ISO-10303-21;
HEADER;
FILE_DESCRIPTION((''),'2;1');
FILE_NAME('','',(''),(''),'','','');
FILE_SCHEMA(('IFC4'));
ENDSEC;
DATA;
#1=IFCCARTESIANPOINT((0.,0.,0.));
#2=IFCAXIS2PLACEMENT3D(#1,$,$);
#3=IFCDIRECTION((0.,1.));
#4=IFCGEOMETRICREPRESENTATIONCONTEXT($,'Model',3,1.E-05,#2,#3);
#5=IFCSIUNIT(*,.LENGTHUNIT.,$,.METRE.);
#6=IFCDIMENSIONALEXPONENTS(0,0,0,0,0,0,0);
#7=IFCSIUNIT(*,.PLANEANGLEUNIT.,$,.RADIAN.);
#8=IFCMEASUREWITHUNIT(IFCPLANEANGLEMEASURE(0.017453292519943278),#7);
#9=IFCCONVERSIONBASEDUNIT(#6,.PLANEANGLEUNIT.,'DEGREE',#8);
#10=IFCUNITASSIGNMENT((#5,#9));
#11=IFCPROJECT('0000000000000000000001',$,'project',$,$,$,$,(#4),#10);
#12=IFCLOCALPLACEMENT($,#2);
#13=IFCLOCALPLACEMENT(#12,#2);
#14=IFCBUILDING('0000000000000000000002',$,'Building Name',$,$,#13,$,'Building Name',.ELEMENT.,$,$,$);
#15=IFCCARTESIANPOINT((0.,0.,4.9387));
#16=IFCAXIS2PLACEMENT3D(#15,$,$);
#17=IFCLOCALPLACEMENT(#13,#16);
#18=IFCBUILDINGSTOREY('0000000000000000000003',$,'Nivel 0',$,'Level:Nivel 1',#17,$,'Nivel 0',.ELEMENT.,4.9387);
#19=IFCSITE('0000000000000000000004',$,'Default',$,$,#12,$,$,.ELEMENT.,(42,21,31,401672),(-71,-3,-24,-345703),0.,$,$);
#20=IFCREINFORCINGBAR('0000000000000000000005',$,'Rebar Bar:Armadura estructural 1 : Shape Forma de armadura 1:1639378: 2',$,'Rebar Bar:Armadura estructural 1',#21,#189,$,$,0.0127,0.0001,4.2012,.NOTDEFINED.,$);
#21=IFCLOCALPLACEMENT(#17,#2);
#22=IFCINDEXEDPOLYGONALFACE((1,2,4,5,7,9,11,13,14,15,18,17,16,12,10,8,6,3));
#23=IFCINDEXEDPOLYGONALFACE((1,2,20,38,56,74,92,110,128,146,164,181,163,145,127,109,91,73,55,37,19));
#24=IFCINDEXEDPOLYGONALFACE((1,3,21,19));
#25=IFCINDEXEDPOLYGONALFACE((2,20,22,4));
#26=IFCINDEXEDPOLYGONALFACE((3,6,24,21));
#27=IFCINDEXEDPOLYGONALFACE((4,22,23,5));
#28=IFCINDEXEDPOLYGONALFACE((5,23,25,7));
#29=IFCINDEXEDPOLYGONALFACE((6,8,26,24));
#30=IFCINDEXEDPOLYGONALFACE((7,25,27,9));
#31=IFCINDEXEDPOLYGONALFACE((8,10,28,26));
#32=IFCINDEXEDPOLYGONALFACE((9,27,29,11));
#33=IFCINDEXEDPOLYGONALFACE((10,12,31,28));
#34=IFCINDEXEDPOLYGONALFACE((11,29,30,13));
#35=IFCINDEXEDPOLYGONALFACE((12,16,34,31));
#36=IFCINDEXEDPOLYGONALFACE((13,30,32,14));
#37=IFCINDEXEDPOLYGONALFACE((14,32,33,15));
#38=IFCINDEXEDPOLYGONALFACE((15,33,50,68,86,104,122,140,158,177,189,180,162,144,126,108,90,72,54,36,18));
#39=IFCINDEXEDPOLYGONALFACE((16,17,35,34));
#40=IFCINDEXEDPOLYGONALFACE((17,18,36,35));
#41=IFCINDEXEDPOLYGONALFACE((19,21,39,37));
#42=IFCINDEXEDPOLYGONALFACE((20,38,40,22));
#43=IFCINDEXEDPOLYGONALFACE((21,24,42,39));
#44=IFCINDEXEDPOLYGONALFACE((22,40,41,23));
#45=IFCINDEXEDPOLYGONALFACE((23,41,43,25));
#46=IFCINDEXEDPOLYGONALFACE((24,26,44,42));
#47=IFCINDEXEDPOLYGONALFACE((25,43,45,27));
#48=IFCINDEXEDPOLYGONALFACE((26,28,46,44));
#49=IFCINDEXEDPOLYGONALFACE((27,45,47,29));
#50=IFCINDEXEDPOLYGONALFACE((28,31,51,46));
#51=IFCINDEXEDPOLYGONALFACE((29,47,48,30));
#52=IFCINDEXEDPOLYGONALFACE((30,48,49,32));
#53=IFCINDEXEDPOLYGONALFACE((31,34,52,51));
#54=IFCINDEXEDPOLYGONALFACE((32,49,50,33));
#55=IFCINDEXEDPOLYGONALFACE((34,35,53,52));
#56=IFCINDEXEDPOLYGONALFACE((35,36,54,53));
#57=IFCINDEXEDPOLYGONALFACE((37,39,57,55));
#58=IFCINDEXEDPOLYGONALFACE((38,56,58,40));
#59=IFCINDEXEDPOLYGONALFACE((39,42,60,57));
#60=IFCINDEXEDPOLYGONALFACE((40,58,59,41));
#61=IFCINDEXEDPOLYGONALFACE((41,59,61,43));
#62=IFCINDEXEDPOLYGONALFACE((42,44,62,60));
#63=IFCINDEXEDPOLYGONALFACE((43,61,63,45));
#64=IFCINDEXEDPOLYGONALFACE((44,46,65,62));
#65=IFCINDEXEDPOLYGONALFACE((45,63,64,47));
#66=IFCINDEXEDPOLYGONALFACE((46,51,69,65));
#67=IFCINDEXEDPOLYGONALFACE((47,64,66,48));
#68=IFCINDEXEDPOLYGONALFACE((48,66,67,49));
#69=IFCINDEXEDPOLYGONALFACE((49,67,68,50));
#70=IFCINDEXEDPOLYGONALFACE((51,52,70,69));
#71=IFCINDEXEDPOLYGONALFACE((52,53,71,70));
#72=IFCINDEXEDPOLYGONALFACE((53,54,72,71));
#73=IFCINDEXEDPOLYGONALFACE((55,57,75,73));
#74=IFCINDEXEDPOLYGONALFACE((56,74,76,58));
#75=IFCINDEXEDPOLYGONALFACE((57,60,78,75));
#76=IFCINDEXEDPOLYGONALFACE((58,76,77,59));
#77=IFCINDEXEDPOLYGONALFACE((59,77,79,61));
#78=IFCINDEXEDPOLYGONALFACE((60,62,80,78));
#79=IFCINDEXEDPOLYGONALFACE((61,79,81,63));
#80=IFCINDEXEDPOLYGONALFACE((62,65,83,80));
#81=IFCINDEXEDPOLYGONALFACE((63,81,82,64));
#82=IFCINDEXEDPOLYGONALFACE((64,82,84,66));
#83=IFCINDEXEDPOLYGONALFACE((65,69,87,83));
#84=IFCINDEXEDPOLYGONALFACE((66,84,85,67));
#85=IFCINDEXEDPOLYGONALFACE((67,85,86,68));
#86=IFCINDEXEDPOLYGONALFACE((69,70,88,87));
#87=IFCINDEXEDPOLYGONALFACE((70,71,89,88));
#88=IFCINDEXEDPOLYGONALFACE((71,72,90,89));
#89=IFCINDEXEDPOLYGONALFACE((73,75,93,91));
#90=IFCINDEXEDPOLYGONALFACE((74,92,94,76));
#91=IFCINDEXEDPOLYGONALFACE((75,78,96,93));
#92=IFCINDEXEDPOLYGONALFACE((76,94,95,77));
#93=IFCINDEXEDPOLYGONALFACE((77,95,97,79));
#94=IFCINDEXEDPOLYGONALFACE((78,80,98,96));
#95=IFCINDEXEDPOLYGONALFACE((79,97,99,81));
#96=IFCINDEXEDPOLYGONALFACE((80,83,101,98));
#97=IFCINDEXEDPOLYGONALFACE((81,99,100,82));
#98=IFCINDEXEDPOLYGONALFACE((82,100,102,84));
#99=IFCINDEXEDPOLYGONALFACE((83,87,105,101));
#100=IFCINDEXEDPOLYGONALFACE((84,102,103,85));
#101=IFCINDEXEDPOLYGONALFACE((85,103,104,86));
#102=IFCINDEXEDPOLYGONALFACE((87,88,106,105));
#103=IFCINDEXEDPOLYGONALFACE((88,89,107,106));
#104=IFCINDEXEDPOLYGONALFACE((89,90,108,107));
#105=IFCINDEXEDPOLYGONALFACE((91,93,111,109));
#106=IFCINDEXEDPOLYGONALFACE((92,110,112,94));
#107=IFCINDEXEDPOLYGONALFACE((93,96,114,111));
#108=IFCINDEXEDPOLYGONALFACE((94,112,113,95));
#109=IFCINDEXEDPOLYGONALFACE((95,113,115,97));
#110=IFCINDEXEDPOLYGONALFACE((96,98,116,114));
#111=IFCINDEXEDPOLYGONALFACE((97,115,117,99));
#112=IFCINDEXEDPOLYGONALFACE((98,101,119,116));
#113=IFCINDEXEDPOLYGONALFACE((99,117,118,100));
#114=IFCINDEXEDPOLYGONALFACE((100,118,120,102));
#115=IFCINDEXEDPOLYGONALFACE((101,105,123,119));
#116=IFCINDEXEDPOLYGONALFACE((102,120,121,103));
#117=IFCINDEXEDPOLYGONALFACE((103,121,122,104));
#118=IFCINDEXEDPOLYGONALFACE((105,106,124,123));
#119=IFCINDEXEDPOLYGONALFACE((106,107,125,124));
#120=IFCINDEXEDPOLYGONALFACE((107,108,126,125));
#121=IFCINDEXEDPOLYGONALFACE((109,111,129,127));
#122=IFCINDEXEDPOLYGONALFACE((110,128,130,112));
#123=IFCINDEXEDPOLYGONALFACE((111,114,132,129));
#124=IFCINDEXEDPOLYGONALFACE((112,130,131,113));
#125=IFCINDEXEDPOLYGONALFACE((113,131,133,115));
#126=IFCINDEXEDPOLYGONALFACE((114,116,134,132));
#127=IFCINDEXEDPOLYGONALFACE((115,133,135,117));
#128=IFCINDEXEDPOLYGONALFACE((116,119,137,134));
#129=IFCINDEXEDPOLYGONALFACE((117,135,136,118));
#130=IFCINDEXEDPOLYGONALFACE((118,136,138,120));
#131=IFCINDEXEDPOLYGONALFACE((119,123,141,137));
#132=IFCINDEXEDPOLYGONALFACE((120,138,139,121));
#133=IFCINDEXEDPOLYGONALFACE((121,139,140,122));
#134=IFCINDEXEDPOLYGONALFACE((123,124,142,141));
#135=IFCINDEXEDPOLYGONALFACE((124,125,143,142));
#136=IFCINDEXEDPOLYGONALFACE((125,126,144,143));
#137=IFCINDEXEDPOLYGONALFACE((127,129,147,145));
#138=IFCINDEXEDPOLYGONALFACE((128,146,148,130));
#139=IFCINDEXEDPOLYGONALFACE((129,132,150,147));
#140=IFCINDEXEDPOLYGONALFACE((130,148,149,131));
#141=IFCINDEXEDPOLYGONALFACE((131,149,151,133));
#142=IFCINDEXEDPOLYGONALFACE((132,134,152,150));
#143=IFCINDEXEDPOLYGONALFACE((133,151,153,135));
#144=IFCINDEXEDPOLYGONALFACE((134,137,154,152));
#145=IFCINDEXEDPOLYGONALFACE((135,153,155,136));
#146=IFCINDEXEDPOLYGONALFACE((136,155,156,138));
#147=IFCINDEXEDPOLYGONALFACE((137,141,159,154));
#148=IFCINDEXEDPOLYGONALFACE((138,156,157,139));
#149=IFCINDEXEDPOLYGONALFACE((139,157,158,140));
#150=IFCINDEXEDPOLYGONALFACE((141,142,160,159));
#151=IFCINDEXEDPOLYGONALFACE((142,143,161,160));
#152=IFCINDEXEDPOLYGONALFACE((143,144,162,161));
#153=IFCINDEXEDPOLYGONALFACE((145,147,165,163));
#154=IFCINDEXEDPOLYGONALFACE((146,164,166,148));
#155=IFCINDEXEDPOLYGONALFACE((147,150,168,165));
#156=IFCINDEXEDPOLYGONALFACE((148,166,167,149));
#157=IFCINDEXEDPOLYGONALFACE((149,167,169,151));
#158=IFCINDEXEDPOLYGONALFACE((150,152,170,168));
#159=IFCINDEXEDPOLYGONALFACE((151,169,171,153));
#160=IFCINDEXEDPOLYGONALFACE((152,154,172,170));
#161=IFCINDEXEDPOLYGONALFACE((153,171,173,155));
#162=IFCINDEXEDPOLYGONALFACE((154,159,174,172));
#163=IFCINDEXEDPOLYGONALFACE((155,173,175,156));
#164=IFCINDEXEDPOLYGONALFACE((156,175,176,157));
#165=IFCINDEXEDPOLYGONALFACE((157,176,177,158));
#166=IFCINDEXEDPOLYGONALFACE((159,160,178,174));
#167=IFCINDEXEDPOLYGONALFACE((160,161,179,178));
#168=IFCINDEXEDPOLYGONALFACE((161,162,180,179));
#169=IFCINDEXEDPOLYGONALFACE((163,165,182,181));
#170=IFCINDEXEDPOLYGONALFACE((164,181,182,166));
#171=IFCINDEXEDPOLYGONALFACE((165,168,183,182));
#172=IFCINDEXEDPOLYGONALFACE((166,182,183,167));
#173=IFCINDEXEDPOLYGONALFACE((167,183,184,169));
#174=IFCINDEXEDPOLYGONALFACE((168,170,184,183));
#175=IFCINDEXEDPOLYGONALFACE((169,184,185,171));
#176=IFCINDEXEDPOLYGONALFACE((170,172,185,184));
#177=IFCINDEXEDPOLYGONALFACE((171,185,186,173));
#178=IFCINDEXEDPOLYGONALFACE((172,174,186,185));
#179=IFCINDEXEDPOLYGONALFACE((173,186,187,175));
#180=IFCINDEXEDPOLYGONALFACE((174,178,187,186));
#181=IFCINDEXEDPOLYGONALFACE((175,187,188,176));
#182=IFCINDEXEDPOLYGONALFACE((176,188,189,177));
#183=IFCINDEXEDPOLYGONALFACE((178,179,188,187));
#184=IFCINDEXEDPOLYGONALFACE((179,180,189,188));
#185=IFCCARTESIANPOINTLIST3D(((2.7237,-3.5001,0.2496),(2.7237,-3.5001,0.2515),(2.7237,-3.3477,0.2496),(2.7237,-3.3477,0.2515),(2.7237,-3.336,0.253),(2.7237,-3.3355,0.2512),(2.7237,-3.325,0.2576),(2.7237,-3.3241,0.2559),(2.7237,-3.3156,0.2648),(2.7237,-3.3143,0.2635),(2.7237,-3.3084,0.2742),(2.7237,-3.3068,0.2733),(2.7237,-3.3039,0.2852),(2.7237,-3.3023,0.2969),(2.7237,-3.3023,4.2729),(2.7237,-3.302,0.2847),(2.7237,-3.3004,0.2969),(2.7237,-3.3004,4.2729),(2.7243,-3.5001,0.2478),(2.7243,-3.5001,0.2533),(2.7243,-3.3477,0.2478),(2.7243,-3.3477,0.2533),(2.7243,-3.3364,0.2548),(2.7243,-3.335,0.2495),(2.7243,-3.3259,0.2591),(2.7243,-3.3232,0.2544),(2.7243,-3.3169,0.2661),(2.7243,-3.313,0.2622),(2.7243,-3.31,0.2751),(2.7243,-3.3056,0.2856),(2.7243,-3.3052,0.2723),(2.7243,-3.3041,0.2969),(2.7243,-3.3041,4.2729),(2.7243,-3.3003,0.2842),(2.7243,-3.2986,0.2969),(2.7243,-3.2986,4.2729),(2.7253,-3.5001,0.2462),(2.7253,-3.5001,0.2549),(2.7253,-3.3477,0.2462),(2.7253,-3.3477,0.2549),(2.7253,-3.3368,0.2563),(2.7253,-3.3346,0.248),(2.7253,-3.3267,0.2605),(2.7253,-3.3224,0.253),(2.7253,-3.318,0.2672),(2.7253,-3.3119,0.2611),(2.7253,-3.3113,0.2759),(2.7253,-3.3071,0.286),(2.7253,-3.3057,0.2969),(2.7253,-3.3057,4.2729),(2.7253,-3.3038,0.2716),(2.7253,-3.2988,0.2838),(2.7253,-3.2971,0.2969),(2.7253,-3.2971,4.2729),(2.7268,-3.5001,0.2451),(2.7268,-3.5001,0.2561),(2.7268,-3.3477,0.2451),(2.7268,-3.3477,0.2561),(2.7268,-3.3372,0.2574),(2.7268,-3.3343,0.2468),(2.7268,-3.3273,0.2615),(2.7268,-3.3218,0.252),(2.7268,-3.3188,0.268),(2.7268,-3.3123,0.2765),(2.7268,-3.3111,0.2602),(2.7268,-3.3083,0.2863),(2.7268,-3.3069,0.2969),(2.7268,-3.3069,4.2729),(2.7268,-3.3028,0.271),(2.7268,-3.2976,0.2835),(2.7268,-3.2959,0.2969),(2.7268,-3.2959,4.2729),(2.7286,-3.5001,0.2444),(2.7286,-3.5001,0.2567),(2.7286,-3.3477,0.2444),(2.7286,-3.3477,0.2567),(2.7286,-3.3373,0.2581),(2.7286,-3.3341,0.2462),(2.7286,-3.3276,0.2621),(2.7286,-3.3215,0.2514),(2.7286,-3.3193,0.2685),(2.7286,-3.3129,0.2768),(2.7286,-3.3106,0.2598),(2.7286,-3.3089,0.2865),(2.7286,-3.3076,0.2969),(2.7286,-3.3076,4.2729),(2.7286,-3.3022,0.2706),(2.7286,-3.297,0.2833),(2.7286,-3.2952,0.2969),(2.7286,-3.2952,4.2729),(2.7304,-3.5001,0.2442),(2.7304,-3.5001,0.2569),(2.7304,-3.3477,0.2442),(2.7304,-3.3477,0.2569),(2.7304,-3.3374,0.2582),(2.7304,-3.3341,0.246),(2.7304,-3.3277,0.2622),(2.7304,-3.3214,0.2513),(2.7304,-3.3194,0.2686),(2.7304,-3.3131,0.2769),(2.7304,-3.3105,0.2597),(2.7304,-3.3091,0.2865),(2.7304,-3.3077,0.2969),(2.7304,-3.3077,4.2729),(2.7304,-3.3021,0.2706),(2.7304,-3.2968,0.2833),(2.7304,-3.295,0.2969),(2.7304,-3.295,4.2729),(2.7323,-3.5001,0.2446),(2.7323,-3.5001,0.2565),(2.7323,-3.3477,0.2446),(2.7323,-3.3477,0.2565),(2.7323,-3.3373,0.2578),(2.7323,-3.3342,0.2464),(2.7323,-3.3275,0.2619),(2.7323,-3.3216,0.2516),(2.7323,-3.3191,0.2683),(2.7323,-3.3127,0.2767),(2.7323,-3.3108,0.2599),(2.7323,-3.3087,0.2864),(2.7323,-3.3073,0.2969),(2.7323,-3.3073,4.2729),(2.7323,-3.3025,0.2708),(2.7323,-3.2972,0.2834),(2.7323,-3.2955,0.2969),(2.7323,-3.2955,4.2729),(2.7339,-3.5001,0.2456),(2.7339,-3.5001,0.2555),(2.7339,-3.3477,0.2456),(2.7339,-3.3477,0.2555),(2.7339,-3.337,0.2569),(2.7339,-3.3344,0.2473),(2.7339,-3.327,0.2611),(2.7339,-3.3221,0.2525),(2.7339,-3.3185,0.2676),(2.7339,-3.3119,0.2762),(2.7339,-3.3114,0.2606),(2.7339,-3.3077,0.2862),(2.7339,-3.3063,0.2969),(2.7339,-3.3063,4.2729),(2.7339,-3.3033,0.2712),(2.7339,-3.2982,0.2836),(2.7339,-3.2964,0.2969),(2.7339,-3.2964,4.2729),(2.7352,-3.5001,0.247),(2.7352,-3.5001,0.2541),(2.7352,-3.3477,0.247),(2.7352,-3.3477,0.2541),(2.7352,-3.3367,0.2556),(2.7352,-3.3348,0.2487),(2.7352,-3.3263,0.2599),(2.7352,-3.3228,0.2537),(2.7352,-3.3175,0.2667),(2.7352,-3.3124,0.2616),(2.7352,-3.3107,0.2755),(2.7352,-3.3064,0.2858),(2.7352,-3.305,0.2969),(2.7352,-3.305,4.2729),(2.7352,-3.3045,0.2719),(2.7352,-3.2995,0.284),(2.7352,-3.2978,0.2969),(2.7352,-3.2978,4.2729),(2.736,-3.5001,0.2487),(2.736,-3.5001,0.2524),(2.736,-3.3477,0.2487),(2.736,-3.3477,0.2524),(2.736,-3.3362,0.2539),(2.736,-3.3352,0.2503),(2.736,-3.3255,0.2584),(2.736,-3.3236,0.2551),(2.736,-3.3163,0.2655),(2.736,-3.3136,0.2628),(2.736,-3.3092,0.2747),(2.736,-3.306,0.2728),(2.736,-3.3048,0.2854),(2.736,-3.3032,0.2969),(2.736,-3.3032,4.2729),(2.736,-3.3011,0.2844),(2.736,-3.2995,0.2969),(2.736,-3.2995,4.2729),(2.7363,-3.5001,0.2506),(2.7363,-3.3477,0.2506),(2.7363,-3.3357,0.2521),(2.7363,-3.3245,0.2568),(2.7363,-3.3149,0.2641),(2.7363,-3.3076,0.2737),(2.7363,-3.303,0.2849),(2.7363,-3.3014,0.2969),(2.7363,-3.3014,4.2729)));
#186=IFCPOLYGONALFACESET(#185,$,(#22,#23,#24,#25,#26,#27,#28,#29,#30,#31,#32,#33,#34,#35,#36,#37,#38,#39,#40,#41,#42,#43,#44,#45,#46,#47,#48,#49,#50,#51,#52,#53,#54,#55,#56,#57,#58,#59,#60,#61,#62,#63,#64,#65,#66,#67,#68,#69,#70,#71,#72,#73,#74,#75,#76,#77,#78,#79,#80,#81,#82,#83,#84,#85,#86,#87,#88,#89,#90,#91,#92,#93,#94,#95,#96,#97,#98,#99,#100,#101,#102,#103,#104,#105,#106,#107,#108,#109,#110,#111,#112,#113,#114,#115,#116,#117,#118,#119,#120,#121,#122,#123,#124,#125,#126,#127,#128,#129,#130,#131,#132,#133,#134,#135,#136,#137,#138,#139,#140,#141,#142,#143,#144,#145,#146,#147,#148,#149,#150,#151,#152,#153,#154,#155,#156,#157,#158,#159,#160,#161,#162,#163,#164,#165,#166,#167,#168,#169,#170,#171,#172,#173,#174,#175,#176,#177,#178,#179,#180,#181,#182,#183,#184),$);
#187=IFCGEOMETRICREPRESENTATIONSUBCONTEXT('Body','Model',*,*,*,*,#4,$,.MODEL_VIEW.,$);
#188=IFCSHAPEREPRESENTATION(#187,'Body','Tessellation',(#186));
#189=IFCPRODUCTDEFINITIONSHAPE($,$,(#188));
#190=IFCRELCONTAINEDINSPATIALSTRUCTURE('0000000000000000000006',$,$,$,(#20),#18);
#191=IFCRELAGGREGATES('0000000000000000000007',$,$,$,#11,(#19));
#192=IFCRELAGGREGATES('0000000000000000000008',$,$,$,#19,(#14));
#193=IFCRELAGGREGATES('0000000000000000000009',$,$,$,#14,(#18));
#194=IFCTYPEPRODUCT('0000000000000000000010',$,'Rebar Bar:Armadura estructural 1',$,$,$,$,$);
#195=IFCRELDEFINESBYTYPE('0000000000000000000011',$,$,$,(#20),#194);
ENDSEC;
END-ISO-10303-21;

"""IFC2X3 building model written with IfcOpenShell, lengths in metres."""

from ifc_helpers import new_model, entity, si_unit, converted_unit, direction, frame, origin, place, context, subcontext, project, spatial, type_object, element, save


model = new_model("IFC2X3")

# Units and contexts
model_context = context("Model", 3, precision=1e-05, world=origin(), true_north=direction((0.0, 1.0)))
body_context = subcontext(model_context, "Body", "Model", "MODEL_VIEW")
ifc_project = project(units=[si_unit("LENGTHUNIT", "METRE"), converted_unit("PLANEANGLEUNIT", "DEGREE", entity("IfcPlaneAngleMeasure", 0.017453292519943278), si_unit("PLANEANGLEUNIT", "RADIAN"), dimensions=[0, 0, 0, 0, 0, 0, 0])], contexts=[model_context])

# Site, building, storey
site_placement = place(None, origin())
site = spatial("IfcSite", under=ifc_project, at=site_placement, Name="Default", CompositionType="ELEMENT", RefLatitude=(42, 21, 31, 401672), RefLongitude=(-71, -3, -24, -345703), RefElevation=0.0)
building_placement = place(site_placement, origin())
building = spatial("IfcBuilding", under=site, at=building_placement, Name="Building Name", LongName="Building Name", CompositionType="ELEMENT")
storey_placement = place(building_placement, frame((0.0, 0.0, 4.9387)))
storey = spatial("IfcBuildingStorey", under=building, at=storey_placement, Name="Nivel 0", ObjectType="Level:Nivel 1", LongName="Nivel 0", CompositionType="ELEMENT", Elevation=4.9387)

# Reinforcing bar
type_product = type_object("IfcTypeProduct", Name="Rebar Bar:Armadura estructural 1")
reinforcing_bar_1_placement = place(storey_placement, origin())
element("IfcReinforcingBar", 1, at=reinforcing_bar_1_placement, inside=storey, type_object=type_product, Name="Rebar Bar:Armadura estructural 1 : Shape Forma de armadura 1:1639378: 2", ObjectType="Rebar Bar:Armadura estructural 1", BarLength=4.2012, BarRole="NOTDEFINED", CrossSectionArea=0.0001, NominalDiameter=0.0127, context=body_context, shape_type="AdvancedSweptSolid", body=[
    entity("IfcSweptDiskSolid", entity("IfcCompositeCurve", [entity("IfcCompositeCurveSegment", "CONTINUOUS", True, entity("IfcPolyline", [entity("IfcCartesianPoint", [2.73, -3.5001, 0.2506]), entity("IfcCartesianPoint", [2.73, -3.3477, 0.2506])])), entity("IfcCompositeCurveSegment", "CONTINUOUS", True, entity("IfcTrimmedCurve", entity("IfcCircle", entity("IfcAxis2Placement3D", entity("IfcCartesianPoint", [2.73, -3.3477, 0.2969]), entity("IfcDirection", [1.0, 0.0, 0.0]), entity("IfcDirection", [0.0, 1.0, 0.0])), 0.0464), [entity("IfcParameterValue", 270.0)], [entity("IfcParameterValue", 360.0)], True, "PARAMETER")), entity("IfcCompositeCurveSegment", "CONTINUOUS", True, entity("IfcPolyline", [entity("IfcCartesianPoint", [2.73, -3.3014, 0.2969]), entity("IfcCartesianPoint", [2.73, -3.3014, 4.2729])]))], False), 0.0063, None, 0.0, 92.0),
])

save(model, "model.ifc")
